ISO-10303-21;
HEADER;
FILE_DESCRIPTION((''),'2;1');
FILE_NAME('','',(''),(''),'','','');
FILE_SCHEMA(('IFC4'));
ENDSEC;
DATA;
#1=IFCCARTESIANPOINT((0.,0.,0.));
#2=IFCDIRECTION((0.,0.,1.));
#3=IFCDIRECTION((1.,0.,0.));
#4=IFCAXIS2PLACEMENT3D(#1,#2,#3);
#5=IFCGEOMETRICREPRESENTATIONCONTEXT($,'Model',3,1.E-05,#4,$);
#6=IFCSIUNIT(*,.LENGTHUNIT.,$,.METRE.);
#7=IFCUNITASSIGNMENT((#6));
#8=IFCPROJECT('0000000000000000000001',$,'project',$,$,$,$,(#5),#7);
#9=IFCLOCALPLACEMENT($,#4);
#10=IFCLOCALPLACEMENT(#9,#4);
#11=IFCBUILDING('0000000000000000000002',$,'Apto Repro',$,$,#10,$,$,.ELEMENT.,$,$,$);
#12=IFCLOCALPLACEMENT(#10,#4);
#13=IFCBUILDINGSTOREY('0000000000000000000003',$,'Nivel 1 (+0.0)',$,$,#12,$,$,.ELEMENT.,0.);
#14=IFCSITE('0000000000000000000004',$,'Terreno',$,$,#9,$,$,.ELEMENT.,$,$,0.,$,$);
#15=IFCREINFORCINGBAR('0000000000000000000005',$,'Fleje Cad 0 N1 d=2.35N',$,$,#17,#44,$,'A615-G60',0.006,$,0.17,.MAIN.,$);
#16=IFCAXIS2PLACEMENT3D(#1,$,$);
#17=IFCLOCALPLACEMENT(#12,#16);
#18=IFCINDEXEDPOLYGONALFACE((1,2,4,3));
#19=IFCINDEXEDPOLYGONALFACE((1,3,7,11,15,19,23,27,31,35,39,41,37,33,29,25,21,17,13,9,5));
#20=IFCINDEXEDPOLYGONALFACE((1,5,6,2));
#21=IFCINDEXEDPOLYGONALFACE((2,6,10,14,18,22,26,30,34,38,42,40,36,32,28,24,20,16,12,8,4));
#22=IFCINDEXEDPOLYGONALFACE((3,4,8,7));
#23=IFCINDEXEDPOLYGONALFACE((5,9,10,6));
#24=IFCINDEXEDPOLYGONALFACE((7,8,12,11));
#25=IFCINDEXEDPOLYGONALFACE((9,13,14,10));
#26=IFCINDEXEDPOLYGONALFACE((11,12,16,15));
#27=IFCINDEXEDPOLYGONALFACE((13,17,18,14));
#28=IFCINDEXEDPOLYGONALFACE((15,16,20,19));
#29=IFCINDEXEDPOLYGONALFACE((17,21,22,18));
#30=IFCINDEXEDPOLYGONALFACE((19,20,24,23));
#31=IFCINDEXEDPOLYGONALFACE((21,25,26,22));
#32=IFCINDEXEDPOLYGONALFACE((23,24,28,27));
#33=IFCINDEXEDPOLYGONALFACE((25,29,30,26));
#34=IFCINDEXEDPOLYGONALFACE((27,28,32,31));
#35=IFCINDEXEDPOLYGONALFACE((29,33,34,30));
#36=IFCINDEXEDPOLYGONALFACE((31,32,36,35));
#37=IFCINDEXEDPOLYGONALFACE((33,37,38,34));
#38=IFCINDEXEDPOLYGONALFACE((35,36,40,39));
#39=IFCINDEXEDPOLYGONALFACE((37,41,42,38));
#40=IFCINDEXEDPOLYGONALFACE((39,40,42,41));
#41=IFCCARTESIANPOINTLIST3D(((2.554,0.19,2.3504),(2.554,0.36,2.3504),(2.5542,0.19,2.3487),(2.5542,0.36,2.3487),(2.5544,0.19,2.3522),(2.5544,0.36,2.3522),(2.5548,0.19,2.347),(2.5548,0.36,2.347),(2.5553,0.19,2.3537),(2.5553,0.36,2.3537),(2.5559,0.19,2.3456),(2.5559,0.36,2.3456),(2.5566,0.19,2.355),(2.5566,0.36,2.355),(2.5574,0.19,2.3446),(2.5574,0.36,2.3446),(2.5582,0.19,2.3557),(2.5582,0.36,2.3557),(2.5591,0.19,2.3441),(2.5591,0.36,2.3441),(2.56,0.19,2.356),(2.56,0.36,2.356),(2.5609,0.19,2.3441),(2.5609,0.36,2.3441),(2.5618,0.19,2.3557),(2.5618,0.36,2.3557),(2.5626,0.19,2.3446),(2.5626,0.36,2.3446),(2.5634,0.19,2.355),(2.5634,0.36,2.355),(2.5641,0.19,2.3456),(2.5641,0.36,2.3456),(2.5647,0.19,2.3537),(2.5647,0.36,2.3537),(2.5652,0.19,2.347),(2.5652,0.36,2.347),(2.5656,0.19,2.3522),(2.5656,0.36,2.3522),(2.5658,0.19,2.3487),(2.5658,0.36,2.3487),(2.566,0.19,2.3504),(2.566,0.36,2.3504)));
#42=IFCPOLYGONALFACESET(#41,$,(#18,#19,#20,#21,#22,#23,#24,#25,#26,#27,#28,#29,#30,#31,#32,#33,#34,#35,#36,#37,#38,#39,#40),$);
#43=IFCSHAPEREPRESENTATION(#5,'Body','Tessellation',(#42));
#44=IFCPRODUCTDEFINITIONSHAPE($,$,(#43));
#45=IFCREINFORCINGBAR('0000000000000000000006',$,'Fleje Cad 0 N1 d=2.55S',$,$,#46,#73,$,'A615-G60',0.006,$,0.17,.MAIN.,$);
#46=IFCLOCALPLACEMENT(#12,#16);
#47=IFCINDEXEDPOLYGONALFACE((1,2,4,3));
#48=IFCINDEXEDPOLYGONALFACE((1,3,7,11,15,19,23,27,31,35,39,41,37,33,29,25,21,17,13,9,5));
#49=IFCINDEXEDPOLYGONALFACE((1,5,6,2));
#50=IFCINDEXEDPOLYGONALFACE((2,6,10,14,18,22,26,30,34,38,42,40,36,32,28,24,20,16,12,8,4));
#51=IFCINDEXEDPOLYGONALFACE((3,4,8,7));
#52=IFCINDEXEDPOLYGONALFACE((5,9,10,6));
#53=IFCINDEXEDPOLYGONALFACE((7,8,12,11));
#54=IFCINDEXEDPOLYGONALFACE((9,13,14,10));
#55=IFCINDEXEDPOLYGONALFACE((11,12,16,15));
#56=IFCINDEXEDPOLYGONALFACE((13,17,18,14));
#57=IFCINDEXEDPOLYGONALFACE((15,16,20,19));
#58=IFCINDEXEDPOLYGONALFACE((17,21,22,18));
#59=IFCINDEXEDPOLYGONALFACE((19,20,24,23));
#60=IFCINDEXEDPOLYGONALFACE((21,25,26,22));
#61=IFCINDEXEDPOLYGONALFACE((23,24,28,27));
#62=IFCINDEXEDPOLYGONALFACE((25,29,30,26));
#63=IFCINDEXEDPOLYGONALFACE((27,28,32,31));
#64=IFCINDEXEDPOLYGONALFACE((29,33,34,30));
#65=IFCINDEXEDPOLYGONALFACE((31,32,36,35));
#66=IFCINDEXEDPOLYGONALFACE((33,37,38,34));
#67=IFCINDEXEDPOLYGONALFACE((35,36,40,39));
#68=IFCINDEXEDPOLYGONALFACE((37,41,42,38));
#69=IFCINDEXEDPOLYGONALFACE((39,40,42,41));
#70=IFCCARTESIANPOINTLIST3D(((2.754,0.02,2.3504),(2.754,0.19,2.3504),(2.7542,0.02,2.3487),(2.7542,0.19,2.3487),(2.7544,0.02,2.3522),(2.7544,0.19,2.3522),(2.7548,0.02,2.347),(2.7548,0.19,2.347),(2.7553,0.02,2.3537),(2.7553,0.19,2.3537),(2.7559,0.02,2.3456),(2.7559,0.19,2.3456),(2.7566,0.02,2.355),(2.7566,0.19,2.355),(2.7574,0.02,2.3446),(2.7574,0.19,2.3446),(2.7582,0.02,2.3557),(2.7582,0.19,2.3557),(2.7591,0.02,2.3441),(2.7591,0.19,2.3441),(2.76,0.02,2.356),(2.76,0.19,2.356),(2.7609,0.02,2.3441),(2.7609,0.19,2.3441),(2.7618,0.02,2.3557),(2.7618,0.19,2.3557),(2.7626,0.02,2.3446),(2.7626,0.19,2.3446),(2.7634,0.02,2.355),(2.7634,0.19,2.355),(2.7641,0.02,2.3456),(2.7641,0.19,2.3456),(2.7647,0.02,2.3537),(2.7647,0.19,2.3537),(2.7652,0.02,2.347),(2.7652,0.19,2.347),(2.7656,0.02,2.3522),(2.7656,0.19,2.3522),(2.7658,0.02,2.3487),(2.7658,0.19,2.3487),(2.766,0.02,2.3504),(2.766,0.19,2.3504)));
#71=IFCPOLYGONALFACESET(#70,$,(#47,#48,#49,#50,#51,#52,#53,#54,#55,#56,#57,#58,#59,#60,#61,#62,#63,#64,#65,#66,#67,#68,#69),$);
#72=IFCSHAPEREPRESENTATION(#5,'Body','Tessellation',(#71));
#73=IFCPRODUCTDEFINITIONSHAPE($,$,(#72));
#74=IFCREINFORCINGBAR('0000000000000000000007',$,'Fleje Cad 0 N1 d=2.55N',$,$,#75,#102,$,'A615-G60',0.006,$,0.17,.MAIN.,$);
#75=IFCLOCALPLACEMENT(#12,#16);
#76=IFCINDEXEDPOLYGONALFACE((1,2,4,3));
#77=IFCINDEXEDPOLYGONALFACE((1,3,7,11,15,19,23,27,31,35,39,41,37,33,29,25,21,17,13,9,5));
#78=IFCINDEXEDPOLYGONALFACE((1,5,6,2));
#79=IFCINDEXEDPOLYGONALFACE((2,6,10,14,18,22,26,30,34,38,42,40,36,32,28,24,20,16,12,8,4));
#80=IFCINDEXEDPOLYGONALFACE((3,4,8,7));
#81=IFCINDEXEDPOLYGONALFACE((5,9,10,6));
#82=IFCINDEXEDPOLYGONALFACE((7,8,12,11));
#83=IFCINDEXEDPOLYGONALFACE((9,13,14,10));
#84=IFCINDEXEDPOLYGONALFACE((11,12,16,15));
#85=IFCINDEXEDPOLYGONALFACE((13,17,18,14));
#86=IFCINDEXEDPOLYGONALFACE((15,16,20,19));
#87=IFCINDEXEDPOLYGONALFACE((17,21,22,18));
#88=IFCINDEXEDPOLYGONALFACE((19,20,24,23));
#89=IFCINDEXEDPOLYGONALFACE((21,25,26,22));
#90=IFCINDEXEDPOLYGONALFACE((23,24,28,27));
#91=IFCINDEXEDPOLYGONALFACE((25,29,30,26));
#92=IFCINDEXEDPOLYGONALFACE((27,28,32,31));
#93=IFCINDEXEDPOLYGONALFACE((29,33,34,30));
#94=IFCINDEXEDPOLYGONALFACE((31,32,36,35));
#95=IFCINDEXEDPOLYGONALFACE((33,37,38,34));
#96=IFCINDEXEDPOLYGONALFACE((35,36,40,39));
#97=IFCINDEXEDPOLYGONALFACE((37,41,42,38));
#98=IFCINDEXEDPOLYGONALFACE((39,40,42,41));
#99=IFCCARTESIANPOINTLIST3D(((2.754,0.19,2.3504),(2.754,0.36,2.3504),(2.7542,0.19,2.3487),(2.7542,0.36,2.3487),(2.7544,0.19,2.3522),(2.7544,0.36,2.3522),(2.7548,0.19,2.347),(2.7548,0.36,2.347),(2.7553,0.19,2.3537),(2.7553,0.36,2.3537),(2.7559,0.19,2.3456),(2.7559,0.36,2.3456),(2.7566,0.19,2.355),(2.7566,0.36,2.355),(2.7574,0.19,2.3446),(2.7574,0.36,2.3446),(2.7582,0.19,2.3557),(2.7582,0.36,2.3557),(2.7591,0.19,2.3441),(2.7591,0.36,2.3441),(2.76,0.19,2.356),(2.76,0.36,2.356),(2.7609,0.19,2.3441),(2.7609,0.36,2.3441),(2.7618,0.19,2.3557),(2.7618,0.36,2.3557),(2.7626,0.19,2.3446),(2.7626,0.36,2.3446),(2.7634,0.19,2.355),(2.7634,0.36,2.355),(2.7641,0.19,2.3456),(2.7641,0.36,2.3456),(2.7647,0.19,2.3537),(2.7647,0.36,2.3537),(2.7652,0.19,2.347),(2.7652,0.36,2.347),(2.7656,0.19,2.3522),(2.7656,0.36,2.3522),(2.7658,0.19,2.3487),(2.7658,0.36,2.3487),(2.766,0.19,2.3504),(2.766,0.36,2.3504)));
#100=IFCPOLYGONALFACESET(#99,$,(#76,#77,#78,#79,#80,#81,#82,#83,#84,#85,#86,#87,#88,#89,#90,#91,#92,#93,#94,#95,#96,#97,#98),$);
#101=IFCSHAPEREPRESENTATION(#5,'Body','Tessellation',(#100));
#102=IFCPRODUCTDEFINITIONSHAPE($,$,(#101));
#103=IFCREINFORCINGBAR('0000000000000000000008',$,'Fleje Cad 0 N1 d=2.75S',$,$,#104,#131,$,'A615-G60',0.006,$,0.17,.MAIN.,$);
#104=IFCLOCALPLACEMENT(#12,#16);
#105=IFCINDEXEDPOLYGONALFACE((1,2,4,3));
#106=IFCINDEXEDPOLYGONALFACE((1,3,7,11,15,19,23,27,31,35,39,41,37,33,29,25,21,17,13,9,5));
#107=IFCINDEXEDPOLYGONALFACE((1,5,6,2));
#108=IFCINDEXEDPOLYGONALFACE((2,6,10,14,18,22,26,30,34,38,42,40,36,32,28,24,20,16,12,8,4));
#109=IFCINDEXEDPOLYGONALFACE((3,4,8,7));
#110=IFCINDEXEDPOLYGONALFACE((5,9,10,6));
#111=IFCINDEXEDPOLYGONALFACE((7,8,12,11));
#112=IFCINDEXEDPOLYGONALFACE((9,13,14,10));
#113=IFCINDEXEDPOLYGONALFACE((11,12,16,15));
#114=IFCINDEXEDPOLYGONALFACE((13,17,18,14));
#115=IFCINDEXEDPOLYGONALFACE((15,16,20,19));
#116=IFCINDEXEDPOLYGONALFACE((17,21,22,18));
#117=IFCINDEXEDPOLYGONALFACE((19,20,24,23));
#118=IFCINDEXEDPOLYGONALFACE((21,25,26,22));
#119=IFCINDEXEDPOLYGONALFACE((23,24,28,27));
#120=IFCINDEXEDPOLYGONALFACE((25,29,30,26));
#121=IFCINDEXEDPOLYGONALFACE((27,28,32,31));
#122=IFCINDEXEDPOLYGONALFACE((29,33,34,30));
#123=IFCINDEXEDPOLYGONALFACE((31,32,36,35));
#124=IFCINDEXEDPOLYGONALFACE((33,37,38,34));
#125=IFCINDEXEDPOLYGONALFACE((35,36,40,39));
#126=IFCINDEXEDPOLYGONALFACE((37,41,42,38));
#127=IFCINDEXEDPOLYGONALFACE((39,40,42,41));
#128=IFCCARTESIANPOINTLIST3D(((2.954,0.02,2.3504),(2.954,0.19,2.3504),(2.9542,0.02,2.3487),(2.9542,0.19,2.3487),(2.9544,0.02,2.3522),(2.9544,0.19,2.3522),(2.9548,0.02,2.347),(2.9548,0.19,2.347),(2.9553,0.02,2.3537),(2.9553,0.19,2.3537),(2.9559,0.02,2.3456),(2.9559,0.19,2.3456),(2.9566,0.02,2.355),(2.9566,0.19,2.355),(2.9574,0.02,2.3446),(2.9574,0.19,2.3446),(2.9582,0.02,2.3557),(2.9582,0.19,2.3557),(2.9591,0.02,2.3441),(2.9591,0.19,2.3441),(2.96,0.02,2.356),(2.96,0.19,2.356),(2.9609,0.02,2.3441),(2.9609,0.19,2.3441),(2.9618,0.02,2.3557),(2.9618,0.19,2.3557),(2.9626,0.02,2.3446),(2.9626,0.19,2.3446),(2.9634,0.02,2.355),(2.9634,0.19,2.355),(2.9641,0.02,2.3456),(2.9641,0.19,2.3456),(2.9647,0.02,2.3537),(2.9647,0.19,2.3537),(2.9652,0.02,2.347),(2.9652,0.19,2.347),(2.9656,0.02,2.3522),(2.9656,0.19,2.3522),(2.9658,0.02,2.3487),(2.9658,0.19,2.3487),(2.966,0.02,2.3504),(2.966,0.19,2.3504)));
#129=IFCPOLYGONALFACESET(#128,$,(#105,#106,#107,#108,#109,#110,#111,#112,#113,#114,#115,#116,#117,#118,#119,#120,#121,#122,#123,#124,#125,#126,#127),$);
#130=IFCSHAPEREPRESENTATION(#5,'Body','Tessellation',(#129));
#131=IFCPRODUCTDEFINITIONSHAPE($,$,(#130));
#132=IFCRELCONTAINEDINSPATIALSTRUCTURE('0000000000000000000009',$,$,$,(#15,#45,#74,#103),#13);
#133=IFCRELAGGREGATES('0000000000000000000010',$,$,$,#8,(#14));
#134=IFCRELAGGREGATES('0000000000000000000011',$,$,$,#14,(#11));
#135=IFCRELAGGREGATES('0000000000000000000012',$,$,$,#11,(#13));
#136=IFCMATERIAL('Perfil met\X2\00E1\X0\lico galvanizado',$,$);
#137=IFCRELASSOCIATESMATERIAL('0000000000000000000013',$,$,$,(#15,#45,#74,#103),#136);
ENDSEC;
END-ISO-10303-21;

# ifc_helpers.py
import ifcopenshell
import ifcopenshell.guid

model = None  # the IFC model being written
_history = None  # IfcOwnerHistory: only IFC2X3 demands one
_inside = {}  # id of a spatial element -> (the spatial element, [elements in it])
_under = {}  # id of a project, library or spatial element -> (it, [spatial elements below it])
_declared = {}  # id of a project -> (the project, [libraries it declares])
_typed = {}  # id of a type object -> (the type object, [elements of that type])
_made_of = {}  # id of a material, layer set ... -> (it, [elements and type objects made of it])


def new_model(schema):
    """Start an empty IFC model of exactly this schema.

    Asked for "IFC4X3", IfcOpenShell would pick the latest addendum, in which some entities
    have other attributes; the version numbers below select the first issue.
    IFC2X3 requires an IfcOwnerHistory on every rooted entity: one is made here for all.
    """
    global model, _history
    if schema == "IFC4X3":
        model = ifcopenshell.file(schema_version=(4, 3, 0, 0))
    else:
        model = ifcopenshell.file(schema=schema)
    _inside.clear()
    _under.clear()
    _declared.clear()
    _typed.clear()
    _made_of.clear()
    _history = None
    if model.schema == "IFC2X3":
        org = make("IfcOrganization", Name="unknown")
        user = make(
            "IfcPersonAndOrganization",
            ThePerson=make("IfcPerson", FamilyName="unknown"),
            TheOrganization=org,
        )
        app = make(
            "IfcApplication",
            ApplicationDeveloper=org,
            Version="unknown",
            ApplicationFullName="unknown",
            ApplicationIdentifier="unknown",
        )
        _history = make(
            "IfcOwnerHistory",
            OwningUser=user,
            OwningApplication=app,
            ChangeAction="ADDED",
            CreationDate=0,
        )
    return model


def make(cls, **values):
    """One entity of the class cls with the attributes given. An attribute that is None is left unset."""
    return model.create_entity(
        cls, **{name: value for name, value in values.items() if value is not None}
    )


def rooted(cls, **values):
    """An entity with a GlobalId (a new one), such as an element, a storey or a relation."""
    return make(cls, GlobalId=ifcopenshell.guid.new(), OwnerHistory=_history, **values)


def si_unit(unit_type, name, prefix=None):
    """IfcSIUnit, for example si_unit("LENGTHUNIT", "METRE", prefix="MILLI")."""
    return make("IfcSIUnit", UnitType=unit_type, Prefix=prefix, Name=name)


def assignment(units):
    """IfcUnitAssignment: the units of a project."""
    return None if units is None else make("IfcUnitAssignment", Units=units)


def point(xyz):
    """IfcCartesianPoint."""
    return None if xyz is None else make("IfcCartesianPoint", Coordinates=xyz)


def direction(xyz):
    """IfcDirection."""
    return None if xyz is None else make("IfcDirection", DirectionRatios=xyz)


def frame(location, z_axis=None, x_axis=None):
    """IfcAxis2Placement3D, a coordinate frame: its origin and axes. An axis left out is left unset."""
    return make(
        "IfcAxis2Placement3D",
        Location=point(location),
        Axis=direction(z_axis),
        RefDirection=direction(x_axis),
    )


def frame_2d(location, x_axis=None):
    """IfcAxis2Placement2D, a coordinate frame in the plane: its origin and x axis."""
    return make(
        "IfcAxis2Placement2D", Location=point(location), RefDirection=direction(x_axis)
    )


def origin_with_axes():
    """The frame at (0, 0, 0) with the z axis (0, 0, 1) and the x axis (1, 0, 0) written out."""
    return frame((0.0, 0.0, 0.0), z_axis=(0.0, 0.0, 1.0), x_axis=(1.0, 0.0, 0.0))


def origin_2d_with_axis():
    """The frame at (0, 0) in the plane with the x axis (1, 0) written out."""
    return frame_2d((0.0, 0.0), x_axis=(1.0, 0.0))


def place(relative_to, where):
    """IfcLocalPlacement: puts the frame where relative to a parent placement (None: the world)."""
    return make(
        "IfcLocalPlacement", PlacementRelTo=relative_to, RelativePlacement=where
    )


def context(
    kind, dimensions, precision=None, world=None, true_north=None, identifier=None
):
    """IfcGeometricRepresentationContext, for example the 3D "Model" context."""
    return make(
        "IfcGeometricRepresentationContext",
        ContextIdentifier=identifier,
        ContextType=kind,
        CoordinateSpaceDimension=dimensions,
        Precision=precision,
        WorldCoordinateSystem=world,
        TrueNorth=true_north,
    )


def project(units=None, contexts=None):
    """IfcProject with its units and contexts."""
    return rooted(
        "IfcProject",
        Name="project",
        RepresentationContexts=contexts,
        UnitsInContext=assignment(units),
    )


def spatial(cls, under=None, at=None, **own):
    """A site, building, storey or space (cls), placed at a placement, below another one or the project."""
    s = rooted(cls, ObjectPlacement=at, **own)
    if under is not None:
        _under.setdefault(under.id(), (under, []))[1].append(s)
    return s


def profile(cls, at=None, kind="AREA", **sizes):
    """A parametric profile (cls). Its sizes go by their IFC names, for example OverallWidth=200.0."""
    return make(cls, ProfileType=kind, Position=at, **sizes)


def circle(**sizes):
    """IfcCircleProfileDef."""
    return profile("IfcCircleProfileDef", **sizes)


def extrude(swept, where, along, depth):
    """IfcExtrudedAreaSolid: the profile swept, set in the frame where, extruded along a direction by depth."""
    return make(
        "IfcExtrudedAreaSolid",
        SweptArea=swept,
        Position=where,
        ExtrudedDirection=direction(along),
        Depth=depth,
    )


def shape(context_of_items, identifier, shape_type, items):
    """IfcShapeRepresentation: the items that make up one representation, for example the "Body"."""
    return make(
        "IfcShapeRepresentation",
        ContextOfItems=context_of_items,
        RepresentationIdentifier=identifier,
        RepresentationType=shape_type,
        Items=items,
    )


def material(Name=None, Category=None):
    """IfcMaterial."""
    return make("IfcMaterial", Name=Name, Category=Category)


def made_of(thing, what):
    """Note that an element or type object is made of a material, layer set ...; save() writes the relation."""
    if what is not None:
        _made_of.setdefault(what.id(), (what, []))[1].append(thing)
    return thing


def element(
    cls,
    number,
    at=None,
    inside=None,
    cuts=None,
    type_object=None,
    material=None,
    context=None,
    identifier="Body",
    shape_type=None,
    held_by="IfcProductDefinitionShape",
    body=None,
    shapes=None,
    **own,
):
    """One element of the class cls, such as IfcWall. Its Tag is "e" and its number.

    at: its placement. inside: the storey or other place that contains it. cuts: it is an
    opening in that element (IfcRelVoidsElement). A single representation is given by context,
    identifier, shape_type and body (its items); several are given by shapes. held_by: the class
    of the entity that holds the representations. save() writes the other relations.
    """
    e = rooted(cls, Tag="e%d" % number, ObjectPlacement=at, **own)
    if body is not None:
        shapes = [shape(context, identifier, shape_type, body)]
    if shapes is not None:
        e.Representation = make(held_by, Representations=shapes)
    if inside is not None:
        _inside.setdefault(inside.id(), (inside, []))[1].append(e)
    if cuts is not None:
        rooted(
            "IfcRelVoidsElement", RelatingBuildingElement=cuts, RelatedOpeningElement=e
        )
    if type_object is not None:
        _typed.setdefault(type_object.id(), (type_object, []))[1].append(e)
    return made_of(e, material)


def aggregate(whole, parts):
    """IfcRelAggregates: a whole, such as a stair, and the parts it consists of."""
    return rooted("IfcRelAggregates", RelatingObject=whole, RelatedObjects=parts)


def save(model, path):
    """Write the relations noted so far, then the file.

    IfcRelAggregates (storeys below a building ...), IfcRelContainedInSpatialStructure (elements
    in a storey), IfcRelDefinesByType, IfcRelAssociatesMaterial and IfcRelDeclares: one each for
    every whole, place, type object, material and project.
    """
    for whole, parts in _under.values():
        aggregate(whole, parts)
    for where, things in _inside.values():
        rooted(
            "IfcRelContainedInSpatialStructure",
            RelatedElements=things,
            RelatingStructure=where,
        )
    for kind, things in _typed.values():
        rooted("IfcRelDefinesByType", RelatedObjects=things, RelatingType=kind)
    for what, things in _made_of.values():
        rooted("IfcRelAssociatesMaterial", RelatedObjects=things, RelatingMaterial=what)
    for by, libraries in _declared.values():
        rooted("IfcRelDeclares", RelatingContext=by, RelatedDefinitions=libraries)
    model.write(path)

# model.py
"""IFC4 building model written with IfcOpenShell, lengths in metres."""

from ifc_helpers import new_model, si_unit, frame, origin_with_axes, origin_2d_with_axis, place, context, project, spatial, circle, extrude, material, element, save


model = new_model("IFC4")

# Units and contexts
model_context = context("Model", 3, precision=1e-05, world=origin_with_axes())
ifc_project = project(units=[si_unit("LENGTHUNIT", "METRE")], contexts=[model_context])

# Site, building, storey
site_placement = place(None, origin_with_axes())
site = spatial("IfcSite", under=ifc_project, at=site_placement, Name="Terreno", CompositionType="ELEMENT", RefElevation=0.0)
building_placement = place(site_placement, origin_with_axes())
building = spatial("IfcBuilding", under=site, at=building_placement, Name="Apto Repro", CompositionType="ELEMENT")
storey_placement = place(building_placement, origin_with_axes())
storey = spatial("IfcBuildingStorey", under=building, at=storey_placement, Name="Nivel 1 (+0.0)", CompositionType="ELEMENT", Elevation=0.0)

# Reinforcing bars
ifc_material = material(Name="Perfil metálico galvanizado")
reinforcing_bar_1_placement = place(storey_placement, origin_with_axes())
element("IfcReinforcingBar", 1, at=reinforcing_bar_1_placement, inside=storey, material=ifc_material, Name="Fleje Cad 0 N1 d=2.35N", SteelGrade="A615-G60", BarLength=0.17, NominalDiameter=0.006, PredefinedType="MAIN", context=model_context, shape_type="SweptSolid", body=[
    extrude(circle(Radius=0.006, at=origin_2d_with_axis()), frame((2.56, 0.19, 2.35), z_axis=(0.0, 1.0, 0.0), x_axis=(0.0, 0.0, 1.0)), (0.0, 0.0, 1.0), 0.17),
])
reinforcing_bar_2_placement = place(storey_placement, origin_with_axes())
element("IfcReinforcingBar", 2, at=reinforcing_bar_2_placement, inside=storey, material=ifc_material, Name="Fleje Cad 0 N1 d=2.55S", SteelGrade="A615-G60", BarLength=0.17, NominalDiameter=0.006, PredefinedType="MAIN", context=model_context, shape_type="SweptSolid", body=[
    extrude(circle(Radius=0.006, at=origin_2d_with_axis()), frame((2.76, 0.02, 2.35), z_axis=(0.0, 1.0, 0.0), x_axis=(0.0, 0.0, 1.0)), (0.0, 0.0, 1.0), 0.17),
])
reinforcing_bar_3_placement = place(storey_placement, origin_with_axes())
element("IfcReinforcingBar", 3, at=reinforcing_bar_3_placement, inside=storey, material=ifc_material, Name="Fleje Cad 0 N1 d=2.55N", SteelGrade="A615-G60", BarLength=0.17, NominalDiameter=0.006, PredefinedType="MAIN", context=model_context, shape_type="SweptSolid", body=[
    extrude(circle(Radius=0.006, at=origin_2d_with_axis()), frame((2.76, 0.19, 2.35), z_axis=(0.0, 1.0, 0.0), x_axis=(0.0, 0.0, 1.0)), (0.0, 0.0, 1.0), 0.17),
])
reinforcing_bar_4_placement = place(storey_placement, origin_with_axes())
element("IfcReinforcingBar", 4, at=reinforcing_bar_4_placement, inside=storey, material=ifc_material, Name="Fleje Cad 0 N1 d=2.75S", SteelGrade="A615-G60", BarLength=0.17, NominalDiameter=0.006, PredefinedType="MAIN", context=model_context, shape_type="SweptSolid", body=[
    extrude(circle(Radius=0.006, at=origin_2d_with_axis()), frame((2.96, 0.02, 2.35), z_axis=(0.0, 1.0, 0.0), x_axis=(0.0, 0.0, 1.0)), (0.0, 0.0, 1.0), 0.17),
])

save(model, "model.ifc")
